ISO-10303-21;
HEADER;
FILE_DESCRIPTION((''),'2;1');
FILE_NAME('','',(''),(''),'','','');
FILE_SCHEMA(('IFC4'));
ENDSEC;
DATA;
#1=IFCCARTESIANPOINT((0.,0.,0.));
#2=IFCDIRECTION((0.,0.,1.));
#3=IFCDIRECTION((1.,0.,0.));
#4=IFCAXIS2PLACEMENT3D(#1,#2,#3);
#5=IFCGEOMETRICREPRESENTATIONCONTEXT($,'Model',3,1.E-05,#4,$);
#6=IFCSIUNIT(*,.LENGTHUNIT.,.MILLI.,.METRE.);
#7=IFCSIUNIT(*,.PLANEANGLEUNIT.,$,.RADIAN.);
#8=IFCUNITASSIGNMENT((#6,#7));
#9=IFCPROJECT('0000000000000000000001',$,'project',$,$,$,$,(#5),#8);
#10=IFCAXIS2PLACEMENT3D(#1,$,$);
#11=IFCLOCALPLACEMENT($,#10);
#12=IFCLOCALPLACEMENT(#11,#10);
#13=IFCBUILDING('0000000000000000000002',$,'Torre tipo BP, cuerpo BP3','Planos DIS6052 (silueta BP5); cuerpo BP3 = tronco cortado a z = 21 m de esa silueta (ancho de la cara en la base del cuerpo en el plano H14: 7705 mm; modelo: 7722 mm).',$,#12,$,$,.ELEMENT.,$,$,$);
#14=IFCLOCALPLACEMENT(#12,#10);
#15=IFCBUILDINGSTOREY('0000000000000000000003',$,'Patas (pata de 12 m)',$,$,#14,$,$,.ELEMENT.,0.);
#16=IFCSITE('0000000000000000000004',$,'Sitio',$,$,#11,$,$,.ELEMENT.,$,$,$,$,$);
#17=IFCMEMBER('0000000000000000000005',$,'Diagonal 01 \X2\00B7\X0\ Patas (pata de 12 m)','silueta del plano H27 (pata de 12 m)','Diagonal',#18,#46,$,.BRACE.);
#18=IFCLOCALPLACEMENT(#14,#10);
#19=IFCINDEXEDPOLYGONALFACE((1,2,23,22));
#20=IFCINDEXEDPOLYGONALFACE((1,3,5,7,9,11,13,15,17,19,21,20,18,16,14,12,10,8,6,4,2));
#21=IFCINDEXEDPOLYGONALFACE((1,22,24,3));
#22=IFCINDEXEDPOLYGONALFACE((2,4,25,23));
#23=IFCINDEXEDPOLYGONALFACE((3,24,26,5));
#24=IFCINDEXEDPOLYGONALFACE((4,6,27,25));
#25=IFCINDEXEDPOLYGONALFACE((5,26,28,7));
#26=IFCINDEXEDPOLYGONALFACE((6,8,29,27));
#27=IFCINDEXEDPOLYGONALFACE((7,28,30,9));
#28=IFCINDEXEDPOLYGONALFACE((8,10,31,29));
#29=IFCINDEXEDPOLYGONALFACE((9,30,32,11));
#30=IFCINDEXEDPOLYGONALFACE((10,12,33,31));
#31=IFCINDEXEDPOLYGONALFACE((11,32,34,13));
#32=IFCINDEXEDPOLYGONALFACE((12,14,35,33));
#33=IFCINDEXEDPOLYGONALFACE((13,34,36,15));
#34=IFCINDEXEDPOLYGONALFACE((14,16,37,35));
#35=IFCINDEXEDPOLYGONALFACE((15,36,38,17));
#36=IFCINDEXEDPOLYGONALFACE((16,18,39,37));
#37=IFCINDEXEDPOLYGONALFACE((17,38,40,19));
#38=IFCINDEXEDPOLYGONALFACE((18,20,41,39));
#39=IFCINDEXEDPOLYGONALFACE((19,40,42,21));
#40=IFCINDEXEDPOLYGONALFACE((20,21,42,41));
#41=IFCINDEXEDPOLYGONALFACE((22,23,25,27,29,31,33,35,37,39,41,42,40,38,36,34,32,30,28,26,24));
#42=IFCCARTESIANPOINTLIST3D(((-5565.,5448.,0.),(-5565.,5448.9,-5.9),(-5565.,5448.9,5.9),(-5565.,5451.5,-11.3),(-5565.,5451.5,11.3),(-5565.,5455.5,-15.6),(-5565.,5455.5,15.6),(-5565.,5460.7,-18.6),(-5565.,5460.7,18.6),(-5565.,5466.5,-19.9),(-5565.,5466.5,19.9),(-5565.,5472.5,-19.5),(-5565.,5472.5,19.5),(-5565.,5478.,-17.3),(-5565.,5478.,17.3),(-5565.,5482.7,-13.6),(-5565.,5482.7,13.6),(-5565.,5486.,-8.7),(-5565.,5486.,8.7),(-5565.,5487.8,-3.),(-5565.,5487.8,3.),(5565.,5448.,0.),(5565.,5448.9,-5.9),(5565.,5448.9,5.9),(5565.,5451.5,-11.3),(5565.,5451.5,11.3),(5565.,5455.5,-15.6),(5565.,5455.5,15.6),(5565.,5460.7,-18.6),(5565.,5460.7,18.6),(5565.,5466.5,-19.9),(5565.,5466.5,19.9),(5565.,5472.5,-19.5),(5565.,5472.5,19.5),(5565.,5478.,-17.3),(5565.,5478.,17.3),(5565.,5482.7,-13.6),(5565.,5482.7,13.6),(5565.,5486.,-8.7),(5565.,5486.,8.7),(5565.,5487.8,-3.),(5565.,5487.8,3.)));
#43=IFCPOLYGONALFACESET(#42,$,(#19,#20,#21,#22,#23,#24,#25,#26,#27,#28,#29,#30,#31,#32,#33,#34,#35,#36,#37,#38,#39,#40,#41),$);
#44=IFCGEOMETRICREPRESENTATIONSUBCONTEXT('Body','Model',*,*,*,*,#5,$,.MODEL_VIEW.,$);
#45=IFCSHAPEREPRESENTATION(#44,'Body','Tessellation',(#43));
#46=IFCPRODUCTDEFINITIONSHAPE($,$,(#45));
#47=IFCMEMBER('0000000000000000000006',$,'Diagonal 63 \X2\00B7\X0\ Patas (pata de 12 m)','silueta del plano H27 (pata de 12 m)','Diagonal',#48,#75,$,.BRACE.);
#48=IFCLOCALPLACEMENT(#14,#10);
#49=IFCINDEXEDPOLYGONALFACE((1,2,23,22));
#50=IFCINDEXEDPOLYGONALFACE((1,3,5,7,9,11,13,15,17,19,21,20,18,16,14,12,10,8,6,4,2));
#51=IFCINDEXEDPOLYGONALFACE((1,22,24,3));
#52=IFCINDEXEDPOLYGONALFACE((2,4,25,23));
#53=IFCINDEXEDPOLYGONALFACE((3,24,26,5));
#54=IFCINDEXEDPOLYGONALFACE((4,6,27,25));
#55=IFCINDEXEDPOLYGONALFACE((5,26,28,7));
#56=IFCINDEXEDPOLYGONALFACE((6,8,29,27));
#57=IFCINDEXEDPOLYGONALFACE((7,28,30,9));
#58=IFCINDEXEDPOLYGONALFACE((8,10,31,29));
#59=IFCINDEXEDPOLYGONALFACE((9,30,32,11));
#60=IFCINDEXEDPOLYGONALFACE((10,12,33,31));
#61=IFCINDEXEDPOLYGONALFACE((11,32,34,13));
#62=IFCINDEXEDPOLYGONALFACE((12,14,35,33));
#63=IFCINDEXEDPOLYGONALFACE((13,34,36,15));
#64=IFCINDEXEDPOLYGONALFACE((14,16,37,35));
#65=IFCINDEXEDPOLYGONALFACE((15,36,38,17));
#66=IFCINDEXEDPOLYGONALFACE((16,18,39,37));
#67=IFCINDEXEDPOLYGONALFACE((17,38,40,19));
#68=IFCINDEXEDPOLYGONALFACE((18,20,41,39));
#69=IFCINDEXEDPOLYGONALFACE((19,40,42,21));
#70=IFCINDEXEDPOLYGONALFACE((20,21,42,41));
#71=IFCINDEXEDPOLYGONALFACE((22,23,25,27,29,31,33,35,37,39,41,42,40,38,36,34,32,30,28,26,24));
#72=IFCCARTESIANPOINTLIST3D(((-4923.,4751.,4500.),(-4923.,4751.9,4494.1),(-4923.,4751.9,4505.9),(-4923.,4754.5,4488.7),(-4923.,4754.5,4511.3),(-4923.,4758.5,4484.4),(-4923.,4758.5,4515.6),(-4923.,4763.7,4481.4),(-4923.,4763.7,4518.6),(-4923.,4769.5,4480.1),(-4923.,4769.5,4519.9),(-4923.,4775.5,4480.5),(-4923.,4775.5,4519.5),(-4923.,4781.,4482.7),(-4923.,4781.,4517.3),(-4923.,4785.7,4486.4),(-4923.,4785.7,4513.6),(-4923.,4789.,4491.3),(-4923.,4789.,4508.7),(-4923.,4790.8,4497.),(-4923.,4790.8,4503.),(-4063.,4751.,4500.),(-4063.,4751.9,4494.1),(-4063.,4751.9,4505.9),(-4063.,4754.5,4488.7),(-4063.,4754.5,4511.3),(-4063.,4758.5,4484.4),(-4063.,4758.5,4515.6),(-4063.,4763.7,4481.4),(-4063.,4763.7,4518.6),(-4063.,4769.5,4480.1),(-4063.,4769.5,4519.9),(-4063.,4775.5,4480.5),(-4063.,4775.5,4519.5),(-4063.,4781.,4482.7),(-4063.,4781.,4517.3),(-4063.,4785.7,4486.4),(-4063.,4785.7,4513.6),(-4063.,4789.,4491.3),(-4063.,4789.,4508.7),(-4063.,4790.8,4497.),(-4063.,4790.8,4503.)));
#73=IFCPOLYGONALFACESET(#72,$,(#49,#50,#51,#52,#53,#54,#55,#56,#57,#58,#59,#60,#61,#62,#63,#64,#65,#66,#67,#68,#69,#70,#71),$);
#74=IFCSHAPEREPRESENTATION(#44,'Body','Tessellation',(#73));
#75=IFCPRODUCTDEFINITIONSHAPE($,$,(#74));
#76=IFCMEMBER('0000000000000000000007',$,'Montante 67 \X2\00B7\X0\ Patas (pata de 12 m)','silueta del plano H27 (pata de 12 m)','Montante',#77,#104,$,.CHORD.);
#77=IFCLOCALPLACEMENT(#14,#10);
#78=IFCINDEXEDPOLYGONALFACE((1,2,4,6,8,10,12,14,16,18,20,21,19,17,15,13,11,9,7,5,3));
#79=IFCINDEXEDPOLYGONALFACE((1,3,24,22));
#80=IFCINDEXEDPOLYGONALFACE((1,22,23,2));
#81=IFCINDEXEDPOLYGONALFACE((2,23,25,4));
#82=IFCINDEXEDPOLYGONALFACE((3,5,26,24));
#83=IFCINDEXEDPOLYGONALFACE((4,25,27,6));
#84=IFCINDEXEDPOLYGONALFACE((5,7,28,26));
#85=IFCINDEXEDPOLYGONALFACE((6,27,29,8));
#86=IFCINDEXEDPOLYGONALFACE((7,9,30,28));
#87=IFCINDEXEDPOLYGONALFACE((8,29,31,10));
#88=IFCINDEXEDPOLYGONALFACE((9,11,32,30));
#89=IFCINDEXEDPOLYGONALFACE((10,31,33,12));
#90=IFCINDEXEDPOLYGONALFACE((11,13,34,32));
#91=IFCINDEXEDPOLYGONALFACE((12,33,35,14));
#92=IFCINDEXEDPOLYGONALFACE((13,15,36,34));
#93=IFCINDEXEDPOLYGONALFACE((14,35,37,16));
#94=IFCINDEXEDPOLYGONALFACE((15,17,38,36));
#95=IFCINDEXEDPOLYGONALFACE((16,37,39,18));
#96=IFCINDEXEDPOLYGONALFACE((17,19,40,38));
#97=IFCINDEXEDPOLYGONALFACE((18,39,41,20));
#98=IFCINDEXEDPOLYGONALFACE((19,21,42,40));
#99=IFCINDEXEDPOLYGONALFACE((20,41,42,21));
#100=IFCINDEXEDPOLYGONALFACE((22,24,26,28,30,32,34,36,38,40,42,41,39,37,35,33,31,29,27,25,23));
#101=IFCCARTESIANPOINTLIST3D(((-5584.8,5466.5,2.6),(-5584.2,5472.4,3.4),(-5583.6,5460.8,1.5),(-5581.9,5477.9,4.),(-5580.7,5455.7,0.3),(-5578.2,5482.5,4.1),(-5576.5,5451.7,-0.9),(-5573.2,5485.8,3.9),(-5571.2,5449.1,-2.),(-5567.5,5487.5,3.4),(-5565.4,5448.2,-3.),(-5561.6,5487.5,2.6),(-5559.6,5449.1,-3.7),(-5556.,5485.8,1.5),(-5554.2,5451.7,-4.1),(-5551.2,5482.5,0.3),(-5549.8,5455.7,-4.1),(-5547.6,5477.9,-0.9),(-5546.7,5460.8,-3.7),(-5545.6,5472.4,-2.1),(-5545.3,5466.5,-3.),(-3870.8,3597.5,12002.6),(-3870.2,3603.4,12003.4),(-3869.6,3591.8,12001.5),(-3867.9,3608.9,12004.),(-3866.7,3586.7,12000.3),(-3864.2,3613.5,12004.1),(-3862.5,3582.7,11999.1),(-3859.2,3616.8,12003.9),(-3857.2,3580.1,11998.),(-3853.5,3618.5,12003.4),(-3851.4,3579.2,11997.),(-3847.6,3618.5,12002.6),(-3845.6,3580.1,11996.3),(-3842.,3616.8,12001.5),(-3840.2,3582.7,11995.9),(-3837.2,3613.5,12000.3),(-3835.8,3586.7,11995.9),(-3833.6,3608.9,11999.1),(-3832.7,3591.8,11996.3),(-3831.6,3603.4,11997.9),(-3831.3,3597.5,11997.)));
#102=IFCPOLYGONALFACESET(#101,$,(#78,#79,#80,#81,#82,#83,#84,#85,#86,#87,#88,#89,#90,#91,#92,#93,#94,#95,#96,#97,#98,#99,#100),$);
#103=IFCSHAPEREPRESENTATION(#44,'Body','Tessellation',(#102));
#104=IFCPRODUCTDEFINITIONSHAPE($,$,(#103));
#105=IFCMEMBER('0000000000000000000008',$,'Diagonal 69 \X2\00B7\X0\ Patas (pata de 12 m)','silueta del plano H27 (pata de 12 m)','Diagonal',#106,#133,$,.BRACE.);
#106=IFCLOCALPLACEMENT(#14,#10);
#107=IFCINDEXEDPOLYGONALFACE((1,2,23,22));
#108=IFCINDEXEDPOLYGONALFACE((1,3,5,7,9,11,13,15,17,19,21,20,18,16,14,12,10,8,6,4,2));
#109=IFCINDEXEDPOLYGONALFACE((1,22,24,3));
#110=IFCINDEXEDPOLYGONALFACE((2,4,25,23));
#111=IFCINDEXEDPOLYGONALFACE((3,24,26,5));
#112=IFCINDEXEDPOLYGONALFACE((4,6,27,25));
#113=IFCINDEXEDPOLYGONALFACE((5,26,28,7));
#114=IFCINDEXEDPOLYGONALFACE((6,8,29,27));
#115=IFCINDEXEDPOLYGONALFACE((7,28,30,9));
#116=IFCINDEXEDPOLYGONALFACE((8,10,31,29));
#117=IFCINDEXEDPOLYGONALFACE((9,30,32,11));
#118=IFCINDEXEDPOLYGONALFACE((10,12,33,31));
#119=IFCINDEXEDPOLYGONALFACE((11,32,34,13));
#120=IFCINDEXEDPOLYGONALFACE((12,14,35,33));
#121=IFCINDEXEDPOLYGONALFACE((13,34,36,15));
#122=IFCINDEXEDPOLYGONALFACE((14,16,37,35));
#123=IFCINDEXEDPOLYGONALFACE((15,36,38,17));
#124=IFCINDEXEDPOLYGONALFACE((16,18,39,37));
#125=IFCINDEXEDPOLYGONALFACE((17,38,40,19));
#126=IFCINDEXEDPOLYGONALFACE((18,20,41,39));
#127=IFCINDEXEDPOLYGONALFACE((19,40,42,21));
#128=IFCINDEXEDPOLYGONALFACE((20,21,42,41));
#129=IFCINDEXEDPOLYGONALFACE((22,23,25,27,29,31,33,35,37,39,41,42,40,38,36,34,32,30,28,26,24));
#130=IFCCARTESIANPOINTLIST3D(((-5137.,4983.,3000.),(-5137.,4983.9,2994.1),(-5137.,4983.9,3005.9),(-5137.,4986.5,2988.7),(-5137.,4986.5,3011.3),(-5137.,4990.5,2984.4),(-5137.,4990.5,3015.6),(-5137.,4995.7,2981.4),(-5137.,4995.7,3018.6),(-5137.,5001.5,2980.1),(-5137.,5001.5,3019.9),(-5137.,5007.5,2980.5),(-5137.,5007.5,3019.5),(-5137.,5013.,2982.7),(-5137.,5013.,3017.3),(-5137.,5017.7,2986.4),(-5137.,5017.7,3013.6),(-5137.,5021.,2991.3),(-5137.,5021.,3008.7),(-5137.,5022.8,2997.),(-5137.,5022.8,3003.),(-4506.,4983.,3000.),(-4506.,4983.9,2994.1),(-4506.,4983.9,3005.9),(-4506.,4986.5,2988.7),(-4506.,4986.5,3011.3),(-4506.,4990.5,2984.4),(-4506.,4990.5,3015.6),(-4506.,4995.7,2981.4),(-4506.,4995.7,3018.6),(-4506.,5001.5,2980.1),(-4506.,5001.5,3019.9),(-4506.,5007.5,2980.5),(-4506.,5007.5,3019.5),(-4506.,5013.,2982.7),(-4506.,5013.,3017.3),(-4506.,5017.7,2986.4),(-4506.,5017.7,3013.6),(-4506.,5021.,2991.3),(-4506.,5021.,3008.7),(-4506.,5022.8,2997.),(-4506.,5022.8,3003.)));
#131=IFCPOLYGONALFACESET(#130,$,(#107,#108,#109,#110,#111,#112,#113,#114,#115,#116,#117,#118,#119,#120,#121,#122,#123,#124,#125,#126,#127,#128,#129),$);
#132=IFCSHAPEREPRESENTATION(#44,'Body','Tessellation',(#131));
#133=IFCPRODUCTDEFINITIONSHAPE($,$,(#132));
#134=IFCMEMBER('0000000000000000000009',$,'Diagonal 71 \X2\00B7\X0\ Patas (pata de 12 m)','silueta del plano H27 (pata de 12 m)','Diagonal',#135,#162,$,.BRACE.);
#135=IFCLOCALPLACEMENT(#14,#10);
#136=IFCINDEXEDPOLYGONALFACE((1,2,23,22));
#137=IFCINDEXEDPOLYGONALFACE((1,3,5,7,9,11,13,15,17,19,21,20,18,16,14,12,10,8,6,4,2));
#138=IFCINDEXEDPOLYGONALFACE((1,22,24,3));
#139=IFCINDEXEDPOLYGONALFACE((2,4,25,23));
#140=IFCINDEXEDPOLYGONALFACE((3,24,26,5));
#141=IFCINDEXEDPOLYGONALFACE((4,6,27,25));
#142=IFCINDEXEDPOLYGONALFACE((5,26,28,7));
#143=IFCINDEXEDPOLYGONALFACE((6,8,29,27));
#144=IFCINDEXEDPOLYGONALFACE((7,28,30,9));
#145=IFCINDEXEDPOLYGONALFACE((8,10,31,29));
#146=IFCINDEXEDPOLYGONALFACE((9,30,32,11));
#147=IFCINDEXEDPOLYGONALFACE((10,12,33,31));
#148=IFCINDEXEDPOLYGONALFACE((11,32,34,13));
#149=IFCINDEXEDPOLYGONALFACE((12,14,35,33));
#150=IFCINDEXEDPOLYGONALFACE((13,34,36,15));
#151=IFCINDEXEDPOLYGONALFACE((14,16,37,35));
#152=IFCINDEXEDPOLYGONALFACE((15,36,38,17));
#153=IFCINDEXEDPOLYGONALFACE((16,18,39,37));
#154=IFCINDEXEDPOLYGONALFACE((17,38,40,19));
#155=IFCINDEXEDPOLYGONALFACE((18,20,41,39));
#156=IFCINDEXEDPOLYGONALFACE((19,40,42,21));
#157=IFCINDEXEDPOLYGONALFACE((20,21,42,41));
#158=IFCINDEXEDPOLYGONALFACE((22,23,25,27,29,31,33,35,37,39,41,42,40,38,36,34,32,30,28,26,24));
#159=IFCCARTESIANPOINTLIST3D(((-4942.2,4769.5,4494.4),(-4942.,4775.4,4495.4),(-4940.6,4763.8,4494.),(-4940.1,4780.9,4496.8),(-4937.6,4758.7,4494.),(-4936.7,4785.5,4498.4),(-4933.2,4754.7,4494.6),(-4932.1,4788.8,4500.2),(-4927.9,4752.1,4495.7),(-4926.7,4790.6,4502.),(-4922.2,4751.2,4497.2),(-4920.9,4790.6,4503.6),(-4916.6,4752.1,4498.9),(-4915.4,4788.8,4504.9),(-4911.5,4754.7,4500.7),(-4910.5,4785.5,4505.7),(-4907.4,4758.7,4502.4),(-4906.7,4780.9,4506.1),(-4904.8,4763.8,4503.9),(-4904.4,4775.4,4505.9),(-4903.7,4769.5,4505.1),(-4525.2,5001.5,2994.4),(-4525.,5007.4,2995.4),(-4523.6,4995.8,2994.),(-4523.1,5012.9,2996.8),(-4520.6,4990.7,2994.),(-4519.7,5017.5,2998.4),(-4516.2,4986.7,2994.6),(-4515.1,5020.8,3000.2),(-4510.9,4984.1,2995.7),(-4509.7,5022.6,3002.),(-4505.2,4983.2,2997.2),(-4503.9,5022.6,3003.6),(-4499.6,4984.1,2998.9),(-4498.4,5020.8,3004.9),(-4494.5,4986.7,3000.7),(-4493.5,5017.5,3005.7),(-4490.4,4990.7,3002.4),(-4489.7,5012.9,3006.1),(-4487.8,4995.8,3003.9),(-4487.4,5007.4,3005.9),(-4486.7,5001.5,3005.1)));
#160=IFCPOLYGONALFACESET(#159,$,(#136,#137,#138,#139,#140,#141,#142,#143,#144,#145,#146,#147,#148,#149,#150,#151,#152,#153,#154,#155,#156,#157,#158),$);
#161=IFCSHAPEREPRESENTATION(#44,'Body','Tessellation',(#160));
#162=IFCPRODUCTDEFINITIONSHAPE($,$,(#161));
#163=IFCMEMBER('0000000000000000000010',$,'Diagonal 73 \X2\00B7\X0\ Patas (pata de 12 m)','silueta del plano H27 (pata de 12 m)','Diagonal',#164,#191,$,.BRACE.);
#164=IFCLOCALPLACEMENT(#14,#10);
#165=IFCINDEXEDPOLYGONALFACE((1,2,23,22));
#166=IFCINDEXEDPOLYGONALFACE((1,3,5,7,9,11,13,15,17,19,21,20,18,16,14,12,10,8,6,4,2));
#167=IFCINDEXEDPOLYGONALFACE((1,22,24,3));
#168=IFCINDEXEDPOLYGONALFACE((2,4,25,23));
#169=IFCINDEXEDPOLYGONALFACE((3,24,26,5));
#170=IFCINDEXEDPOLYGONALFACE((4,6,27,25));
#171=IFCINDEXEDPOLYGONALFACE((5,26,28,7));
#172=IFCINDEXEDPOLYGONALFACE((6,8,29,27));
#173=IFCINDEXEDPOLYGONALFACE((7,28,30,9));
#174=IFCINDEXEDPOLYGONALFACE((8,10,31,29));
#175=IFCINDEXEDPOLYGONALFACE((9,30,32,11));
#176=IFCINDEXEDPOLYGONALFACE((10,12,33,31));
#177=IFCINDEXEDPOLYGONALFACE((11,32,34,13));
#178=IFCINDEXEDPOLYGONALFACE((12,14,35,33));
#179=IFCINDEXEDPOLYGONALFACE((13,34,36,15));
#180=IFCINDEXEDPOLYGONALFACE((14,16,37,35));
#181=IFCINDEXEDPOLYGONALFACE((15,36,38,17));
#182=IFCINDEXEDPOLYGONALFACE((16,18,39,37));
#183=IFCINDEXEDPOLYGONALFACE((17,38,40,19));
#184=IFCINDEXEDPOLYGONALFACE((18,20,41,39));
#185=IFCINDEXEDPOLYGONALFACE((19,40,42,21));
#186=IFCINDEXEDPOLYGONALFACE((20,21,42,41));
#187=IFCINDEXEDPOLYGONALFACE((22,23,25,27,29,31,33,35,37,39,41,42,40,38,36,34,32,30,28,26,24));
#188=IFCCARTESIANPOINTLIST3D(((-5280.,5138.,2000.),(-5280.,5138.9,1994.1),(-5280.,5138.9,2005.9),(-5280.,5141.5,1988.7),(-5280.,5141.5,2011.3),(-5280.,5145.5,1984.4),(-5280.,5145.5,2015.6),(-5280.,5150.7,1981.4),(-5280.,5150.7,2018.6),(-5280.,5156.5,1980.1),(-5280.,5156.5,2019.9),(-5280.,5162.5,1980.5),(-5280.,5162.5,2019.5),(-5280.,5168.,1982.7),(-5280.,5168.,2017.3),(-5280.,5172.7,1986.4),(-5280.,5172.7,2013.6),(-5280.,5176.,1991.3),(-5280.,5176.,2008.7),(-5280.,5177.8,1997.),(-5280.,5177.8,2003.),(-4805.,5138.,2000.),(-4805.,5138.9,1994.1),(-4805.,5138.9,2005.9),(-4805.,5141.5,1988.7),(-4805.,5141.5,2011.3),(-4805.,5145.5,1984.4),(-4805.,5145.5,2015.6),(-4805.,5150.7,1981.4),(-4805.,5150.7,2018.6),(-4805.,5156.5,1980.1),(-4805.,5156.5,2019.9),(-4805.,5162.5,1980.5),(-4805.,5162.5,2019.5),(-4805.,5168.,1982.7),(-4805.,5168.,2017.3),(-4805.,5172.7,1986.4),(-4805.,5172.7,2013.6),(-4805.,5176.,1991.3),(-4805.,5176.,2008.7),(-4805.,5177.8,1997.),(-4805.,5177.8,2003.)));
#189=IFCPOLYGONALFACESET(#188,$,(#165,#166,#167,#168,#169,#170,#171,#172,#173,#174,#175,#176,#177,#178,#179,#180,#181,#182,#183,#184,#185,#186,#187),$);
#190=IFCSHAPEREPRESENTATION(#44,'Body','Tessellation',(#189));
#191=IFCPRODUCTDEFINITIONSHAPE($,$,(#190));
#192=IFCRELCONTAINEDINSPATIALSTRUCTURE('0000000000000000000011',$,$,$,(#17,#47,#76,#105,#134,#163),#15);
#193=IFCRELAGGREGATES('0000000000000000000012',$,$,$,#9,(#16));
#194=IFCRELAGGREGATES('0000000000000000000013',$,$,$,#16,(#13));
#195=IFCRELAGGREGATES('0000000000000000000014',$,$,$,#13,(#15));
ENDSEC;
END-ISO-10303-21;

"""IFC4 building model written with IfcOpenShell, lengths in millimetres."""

from ifc_helpers import new_model, si_unit, frame, origin, origin_with_axes, place, context, subcontext, project, spatial, circle, extrude, element, save


model = new_model("IFC4")

# Units and contexts
model_context = context("Model", 3, precision=1e-05, world=origin_with_axes())
body_context = subcontext(model_context, "Body", "Model", "MODEL_VIEW")
ifc_project = project(units=[si_unit("LENGTHUNIT", "METRE", prefix="MILLI"), si_unit("PLANEANGLEUNIT", "RADIAN")], contexts=[model_context])

# Site, building, storey
site_placement = place(None, origin())
site = spatial("IfcSite", under=ifc_project, at=site_placement, Name="Sitio", CompositionType="ELEMENT")
building_placement = place(site_placement, origin())
building = spatial("IfcBuilding", under=site, at=building_placement, Name="Torre tipo BP, cuerpo BP3", Description="Planos DIS6052 (silueta BP5); cuerpo BP3 = tronco cortado a z = 21 m de esa silueta (ancho de la cara en la base del cuerpo en el plano H14: 7705 mm; modelo: 7722 mm).", CompositionType="ELEMENT")
storey_placement = place(building_placement, origin())
storey = spatial("IfcBuildingStorey", under=building, at=storey_placement, Name="Patas (pata de 12 m)", CompositionType="ELEMENT", Elevation=0.0)

# Members
member_1_placement = place(storey_placement, frame((-5565.0, 5468.0, 0.0), z_axis=(1.0, 0.0, 0.0), x_axis=(0.0, -1.0, 0.0)))
element("IfcMember", 1, at=member_1_placement, inside=storey, Name="Diagonal 01 · Patas (pata de 12 m)", Description="silueta del plano H27 (pata de 12 m)", ObjectType="Diagonal", PredefinedType="BRACE", context=body_context, shape_type="SweptSolid", body=[
    extrude(circle(Radius=20.0), None, (0.0, 0.0, 1.0), 11130.0),
])
member_2_placement = place(storey_placement, frame((-4923.0, 4771.0, 4500.0), z_axis=(1.0, 0.0, 0.0), x_axis=(0.0, -1.0, 0.0)))
element("IfcMember", 2, at=member_2_placement, inside=storey, Name="Diagonal 63 · Patas (pata de 12 m)", Description="silueta del plano H27 (pata de 12 m)", ObjectType="Diagonal", PredefinedType="BRACE", context=body_context, shape_type="SweptSolid", body=[
    extrude(circle(Radius=20.0), None, (0.0, 0.0, 1.0), 860.0),
])
member_3_placement = place(storey_placement, frame((-5565.0, 5468.0, 0.0), z_axis=(0.139747, -0.152384, 0.978391), x_axis=(-0.021547, -0.988321, -0.150853)))
element("IfcMember", 3, at=member_3_placement, inside=storey, Name="Montante 67 · Patas (pata de 12 m)", Description="silueta del plano H27 (pata de 12 m)", ObjectType="Montante", PredefinedType="CHORD", context=body_context, shape_type="SweptSolid", body=[
    extrude(circle(Radius=20.0), None, (0.0, 0.0, 1.0), 12265.0),
])
member_4_placement = place(storey_placement, frame((-5137.0, 5003.0, 3000.0), z_axis=(1.0, 0.0, 0.0), x_axis=(0.0, -1.0, 0.0)))
element("IfcMember", 4, at=member_4_placement, inside=storey, Name="Diagonal 69 · Patas (pata de 12 m)", Description="silueta del plano H27 (pata de 12 m)", ObjectType="Diagonal", PredefinedType="BRACE", context=body_context, shape_type="SweptSolid", body=[
    extrude(circle(Radius=20.0), None, (0.0, 0.0, 1.0), 631.0),
])
member_5_placement = place(storey_placement, frame((-4506.0, 5003.0, 3000.0), z_axis=(-0.264917, -0.147388, 0.95294), x_axis=(0.039477, -0.989079, -0.142003)))
element("IfcMember", 5, at=member_5_placement, inside=storey, Name="Diagonal 71 · Patas (pata de 12 m)", Description="silueta del plano H27 (pata de 12 m)", ObjectType="Diagonal", PredefinedType="BRACE", context=body_context, shape_type="SweptSolid", body=[
    extrude(circle(Radius=20.0), None, (0.0, 0.0, 1.0), 1574.1),
])
member_6_placement = place(storey_placement, frame((-5280.0, 5158.0, 2000.0), z_axis=(1.0, 0.0, 0.0), x_axis=(0.0, -1.0, 0.0)))
element("IfcMember", 6, at=member_6_placement, inside=storey, Name="Diagonal 73 · Patas (pata de 12 m)", Description="silueta del plano H27 (pata de 12 m)", ObjectType="Diagonal", PredefinedType="BRACE", context=body_context, shape_type="SweptSolid", body=[
    extrude(circle(Radius=20.0), None, (0.0, 0.0, 1.0), 475.0),
])

save(model, "model.ifc")
